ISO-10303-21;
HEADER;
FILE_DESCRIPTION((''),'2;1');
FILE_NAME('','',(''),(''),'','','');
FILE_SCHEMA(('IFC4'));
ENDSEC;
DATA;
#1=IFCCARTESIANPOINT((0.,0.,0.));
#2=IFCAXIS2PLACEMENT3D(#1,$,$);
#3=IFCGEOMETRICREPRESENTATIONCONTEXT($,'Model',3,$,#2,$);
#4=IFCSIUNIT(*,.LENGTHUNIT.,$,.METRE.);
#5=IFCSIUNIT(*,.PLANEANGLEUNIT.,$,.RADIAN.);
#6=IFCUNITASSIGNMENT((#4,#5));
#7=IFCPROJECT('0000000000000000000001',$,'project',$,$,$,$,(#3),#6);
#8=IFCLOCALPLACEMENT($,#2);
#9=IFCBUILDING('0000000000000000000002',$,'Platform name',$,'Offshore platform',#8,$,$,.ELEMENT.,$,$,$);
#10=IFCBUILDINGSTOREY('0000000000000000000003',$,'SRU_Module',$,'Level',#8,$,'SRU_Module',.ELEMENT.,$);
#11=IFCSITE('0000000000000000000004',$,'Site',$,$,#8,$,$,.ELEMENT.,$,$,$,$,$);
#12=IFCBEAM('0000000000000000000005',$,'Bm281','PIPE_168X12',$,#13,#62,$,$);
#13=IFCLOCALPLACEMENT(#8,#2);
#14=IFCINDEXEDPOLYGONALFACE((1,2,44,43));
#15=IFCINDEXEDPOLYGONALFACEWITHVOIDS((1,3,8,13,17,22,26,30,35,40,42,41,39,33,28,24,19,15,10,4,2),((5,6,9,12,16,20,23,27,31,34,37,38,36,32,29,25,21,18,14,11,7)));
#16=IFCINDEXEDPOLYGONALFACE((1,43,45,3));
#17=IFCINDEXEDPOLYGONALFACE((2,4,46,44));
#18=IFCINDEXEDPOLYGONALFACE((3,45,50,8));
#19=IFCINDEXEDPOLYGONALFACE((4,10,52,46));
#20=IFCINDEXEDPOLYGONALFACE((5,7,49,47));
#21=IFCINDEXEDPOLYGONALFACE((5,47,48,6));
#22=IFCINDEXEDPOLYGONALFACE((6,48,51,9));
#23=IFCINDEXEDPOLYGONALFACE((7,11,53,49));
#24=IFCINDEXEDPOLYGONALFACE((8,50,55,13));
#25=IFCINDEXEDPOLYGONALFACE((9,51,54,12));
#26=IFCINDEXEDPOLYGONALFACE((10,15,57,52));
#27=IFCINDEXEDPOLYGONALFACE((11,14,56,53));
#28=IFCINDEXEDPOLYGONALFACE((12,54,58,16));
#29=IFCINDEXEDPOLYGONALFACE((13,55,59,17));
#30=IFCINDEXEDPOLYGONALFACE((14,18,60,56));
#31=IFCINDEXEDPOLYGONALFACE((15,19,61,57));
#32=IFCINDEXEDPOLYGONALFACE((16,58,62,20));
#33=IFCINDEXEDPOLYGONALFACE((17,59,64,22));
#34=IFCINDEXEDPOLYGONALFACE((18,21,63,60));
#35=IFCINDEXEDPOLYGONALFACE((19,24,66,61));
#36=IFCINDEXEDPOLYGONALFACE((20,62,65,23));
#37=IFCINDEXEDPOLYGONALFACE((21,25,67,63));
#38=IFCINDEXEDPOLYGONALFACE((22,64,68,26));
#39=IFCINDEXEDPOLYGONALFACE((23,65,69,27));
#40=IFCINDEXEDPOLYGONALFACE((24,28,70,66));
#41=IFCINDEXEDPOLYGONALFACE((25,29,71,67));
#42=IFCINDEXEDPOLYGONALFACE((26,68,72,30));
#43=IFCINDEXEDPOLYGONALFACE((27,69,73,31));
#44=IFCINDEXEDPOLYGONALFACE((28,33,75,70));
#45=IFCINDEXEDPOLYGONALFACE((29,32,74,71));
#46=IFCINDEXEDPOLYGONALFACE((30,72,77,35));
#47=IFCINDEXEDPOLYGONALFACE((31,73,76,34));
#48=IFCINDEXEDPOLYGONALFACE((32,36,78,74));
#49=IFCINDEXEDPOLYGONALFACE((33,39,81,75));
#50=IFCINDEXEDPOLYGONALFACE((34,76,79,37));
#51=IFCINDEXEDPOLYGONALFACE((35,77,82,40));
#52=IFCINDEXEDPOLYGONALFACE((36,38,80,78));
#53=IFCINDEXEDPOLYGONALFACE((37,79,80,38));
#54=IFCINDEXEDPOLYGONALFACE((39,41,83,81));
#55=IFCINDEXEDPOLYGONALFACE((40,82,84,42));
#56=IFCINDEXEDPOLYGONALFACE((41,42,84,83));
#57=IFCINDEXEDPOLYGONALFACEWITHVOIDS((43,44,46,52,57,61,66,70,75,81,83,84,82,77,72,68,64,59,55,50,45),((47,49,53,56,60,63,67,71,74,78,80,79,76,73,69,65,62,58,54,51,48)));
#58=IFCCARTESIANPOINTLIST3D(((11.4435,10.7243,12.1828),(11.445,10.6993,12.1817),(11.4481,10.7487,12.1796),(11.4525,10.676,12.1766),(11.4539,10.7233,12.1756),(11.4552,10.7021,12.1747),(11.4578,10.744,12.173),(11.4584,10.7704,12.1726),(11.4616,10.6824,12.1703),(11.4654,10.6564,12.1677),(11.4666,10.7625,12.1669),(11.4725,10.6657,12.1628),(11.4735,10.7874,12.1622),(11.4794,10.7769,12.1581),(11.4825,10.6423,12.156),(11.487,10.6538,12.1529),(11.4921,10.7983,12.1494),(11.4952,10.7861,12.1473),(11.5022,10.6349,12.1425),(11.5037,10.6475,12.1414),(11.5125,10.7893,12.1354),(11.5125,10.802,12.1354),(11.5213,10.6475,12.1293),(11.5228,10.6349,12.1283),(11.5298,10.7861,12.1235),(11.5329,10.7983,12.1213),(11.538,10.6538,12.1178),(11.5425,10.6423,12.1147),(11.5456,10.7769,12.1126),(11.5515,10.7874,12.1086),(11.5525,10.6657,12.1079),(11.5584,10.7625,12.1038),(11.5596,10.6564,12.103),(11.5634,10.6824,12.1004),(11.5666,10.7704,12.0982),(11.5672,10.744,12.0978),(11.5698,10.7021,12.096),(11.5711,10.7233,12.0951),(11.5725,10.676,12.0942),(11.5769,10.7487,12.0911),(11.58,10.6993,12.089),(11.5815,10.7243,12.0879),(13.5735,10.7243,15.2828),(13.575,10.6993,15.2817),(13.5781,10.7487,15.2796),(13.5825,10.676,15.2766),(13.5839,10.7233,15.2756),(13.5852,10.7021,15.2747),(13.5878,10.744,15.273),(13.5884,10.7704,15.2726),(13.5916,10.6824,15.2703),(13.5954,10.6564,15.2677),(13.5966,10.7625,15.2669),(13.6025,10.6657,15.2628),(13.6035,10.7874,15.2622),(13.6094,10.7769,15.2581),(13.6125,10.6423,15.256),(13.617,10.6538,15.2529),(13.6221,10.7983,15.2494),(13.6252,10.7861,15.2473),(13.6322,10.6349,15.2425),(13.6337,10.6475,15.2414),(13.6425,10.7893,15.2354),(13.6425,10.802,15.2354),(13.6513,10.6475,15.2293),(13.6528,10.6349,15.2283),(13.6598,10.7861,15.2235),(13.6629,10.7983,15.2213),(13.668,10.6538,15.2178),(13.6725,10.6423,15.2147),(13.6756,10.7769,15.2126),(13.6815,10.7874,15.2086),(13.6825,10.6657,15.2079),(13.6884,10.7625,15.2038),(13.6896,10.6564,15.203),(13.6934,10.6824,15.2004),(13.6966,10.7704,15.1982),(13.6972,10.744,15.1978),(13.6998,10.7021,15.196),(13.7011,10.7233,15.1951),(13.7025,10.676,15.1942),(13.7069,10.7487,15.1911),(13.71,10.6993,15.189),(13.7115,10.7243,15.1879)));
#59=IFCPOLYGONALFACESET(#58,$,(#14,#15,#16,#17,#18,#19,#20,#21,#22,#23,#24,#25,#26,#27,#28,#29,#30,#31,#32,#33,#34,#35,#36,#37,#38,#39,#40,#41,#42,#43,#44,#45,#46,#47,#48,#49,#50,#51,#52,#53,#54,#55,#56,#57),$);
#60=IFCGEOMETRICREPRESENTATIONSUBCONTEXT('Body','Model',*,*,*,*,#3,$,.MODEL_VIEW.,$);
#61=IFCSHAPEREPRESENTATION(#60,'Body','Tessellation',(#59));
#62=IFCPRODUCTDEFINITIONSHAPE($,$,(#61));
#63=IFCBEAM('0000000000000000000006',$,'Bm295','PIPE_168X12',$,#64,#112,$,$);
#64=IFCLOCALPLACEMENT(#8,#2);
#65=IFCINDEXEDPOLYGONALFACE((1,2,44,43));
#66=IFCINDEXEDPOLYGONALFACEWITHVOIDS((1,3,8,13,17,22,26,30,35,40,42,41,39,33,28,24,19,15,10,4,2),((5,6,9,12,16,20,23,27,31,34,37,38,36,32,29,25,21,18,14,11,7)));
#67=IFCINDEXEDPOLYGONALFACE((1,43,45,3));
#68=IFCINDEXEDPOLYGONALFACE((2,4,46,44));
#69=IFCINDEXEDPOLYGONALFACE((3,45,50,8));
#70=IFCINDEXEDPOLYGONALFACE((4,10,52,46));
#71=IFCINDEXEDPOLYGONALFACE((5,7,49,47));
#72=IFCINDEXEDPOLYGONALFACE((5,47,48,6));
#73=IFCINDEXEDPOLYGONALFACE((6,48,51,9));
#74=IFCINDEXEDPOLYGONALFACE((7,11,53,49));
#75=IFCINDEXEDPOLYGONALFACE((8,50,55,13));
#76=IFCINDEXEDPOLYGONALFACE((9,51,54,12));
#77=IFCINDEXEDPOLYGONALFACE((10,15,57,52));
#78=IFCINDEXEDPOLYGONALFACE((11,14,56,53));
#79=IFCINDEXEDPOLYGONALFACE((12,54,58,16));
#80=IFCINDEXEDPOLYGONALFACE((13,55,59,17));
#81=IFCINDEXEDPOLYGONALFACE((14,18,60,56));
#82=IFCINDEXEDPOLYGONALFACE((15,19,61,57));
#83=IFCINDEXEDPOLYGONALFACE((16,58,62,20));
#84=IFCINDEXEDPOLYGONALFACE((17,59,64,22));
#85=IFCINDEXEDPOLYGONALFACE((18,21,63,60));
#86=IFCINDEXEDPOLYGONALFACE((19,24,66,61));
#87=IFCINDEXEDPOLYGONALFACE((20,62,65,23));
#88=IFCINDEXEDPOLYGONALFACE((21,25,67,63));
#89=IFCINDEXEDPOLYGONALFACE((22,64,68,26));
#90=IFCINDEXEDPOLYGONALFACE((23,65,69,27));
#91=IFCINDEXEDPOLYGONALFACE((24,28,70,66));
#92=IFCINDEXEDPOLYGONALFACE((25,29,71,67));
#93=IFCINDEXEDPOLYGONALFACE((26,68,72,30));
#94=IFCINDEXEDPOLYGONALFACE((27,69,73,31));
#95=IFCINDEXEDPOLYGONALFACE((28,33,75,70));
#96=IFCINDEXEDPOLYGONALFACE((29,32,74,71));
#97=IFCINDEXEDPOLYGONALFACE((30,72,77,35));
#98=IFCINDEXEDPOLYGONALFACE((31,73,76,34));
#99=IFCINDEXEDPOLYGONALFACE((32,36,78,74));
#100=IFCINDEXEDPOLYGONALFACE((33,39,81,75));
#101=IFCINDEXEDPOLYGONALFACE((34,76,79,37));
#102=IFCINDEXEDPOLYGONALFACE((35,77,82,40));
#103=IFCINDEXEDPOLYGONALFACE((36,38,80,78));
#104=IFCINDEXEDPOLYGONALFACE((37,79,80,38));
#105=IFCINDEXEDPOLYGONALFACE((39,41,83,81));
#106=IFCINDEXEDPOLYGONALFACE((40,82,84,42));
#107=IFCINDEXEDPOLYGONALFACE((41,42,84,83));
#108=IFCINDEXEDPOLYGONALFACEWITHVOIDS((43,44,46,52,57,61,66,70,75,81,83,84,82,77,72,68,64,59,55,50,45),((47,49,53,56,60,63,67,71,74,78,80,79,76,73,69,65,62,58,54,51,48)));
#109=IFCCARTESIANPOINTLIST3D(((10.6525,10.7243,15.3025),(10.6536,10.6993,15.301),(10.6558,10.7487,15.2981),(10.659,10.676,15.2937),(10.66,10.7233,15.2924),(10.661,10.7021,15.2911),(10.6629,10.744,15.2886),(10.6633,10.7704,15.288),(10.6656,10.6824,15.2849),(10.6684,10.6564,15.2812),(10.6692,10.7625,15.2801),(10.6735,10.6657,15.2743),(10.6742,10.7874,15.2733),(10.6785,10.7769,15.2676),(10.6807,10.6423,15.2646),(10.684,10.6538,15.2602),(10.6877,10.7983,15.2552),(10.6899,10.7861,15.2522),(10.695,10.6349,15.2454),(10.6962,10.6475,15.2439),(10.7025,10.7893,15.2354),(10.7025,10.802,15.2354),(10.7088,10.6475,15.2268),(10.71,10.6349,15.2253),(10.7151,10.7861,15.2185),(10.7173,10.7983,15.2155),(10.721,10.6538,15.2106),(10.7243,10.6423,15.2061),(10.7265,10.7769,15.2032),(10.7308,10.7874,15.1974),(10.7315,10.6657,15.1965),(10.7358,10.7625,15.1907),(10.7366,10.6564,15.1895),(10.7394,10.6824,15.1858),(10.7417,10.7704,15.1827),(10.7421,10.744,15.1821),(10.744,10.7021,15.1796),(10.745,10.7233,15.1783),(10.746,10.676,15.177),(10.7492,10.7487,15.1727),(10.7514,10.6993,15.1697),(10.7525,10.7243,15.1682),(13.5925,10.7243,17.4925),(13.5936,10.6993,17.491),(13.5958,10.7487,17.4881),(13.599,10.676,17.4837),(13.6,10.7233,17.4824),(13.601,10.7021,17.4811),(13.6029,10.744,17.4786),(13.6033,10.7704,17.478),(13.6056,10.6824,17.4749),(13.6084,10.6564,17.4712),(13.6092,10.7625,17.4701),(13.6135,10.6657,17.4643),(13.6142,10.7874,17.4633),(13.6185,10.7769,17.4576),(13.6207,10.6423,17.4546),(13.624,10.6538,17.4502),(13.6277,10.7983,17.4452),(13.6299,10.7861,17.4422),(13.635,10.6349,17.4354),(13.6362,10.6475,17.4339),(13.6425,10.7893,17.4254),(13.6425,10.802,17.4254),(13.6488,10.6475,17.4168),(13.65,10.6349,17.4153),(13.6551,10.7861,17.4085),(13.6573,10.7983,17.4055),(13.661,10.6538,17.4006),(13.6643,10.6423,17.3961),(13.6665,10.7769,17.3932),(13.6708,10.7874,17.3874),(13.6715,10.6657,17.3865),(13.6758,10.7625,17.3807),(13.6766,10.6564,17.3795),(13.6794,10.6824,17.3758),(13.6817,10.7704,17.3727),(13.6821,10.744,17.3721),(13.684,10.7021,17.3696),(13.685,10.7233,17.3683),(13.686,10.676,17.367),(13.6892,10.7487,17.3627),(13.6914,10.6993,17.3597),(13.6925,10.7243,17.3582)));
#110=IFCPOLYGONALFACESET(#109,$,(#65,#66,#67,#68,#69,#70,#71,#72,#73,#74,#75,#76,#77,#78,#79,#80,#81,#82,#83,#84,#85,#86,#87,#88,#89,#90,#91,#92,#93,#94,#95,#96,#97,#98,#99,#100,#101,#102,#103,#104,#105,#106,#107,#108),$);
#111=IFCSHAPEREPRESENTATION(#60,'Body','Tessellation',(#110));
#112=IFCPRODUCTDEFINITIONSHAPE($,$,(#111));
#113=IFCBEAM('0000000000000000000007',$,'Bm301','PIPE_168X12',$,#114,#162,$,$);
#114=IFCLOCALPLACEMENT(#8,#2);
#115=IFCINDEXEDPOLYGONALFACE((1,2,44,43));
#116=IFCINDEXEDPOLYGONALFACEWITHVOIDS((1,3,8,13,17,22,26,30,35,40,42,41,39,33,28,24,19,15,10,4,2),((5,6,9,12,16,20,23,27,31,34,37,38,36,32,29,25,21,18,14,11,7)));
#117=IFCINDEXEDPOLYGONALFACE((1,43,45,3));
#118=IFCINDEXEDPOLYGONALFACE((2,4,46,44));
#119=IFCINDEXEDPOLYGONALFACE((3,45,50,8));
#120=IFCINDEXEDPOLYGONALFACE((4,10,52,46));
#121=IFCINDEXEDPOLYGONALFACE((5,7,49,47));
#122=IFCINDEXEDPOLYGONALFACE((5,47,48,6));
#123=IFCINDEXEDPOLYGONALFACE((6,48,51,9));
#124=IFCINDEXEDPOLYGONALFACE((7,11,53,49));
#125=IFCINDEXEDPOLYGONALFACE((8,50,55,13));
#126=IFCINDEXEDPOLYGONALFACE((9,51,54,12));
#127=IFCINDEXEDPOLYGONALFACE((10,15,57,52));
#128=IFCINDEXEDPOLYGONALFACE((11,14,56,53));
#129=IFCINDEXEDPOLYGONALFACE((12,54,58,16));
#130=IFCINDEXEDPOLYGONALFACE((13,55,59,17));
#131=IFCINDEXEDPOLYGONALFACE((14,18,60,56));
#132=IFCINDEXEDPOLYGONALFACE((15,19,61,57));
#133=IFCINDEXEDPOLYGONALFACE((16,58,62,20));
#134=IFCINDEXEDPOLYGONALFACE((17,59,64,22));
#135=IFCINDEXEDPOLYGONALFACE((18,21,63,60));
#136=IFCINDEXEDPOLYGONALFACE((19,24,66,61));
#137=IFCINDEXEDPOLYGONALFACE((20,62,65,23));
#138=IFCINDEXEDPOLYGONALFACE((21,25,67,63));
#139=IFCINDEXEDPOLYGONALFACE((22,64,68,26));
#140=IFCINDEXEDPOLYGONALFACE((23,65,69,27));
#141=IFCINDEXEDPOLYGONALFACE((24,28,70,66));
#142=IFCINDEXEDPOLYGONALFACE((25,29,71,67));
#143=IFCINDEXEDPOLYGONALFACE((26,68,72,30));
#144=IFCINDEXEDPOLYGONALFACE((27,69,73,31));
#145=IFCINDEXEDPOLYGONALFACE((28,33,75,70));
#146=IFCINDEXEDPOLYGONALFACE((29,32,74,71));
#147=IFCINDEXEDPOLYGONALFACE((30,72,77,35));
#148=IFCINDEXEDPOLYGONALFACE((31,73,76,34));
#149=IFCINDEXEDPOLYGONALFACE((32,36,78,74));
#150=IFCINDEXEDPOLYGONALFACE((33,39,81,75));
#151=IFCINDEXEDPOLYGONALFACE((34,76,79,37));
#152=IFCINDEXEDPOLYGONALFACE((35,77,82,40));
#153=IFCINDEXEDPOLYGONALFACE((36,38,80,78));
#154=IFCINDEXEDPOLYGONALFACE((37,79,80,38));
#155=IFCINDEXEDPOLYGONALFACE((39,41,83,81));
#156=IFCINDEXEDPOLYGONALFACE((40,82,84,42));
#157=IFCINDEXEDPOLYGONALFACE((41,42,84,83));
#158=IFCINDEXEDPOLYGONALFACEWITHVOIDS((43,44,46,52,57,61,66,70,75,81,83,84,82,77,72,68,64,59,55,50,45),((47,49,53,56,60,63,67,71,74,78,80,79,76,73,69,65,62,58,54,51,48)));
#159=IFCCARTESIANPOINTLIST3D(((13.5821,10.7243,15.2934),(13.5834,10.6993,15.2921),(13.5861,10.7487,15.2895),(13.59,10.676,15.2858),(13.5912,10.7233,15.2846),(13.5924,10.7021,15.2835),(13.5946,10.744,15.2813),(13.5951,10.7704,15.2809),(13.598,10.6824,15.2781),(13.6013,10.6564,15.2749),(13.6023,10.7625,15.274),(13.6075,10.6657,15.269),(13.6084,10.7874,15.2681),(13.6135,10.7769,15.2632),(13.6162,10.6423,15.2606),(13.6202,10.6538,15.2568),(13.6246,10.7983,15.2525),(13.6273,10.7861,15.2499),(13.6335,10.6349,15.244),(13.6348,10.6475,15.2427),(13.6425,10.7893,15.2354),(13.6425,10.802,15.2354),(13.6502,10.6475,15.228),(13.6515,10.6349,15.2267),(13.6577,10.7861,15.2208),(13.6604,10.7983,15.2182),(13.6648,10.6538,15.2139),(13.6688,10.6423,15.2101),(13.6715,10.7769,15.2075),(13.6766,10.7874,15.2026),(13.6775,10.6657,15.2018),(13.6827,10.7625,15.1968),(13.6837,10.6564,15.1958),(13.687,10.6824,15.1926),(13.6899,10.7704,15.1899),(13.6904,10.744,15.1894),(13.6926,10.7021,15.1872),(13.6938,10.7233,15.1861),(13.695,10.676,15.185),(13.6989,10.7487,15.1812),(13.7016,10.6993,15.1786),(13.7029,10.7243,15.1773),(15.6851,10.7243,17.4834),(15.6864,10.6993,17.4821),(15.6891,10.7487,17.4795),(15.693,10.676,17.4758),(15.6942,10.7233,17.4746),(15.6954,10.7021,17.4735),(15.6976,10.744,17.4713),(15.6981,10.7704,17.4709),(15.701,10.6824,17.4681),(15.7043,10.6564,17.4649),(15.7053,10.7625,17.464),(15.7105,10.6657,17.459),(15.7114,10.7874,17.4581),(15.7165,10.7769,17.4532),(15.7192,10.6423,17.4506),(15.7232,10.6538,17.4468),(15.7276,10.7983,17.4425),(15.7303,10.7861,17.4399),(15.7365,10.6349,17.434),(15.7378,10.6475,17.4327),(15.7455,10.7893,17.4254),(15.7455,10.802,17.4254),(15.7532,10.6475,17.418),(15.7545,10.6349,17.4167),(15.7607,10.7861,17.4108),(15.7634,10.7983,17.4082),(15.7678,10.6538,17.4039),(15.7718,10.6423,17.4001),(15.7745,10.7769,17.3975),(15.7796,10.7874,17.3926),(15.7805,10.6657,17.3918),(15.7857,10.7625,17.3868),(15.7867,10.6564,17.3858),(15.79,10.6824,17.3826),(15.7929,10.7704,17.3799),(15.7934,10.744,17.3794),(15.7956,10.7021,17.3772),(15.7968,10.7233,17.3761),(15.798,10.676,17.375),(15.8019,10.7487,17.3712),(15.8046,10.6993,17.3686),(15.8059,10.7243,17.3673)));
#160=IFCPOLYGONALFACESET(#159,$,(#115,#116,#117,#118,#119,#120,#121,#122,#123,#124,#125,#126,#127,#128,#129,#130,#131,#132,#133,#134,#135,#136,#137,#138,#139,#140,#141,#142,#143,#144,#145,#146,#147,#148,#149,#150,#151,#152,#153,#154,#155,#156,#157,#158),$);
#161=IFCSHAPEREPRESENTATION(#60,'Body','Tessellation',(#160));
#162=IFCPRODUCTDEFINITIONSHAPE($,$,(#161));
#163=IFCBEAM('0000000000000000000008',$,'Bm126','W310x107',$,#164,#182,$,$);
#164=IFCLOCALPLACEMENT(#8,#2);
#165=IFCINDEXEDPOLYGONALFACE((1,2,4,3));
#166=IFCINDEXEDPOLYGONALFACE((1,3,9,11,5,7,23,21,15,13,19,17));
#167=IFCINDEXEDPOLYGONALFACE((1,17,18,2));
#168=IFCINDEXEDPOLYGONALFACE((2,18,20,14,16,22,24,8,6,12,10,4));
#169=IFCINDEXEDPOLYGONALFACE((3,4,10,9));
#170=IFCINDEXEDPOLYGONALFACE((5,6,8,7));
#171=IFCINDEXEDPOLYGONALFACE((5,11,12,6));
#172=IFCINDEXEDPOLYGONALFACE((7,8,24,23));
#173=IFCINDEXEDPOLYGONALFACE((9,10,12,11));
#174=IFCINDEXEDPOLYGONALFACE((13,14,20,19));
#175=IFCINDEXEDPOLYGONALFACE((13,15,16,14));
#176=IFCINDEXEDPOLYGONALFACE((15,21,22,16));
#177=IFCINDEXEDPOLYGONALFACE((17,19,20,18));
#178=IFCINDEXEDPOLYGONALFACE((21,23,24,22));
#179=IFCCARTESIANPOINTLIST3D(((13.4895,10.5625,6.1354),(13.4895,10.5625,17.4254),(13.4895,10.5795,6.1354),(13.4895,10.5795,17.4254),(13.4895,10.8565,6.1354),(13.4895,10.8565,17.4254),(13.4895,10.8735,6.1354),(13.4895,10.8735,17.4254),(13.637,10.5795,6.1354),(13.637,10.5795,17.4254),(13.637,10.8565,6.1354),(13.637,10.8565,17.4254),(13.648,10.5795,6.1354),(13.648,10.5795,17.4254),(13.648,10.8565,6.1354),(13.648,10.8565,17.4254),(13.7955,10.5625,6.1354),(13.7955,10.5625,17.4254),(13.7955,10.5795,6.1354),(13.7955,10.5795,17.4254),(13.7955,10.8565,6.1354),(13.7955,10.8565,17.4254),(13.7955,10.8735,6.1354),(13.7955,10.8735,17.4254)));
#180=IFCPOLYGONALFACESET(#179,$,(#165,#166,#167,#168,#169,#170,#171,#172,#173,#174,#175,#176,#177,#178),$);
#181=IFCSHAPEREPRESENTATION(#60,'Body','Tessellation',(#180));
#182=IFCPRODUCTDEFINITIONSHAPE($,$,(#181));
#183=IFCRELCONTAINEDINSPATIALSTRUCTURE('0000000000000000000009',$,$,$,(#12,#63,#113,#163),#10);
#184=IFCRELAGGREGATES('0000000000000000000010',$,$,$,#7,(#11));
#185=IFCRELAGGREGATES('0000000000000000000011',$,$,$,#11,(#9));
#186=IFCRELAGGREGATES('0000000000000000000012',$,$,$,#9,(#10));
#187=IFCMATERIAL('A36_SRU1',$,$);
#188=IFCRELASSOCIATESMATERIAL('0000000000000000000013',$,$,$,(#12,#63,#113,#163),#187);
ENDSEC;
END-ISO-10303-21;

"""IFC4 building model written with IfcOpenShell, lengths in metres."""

from ifc_helpers import new_model, si_unit, frame, origin, origin_with_axes, origin_2d, place, context, subcontext, project, spatial, hollow_circle, i_section, extrude, source, transform, mapped, material, element, save


model = new_model("IFC4")

# Units and contexts
model_context = context("Model", 3, world=origin())
body_context = subcontext(model_context, "Body", "Model", "MODEL_VIEW")
ifc_project = project(units=[si_unit("LENGTHUNIT", "METRE"), si_unit("PLANEANGLEUNIT", "RADIAN")], contexts=[model_context])

# Site, building, storey
placement_1 = place(None, origin())
site = spatial("IfcSite", under=ifc_project, at=placement_1, Name="Site", CompositionType="ELEMENT")
building = spatial("IfcBuilding", under=site, at=placement_1, Name="Platform name", ObjectType="Offshore platform", CompositionType="ELEMENT")
storey = spatial("IfcBuildingStorey", under=building, at=placement_1, Name="SRU_Module", ObjectType="Level", LongName="SRU_Module", CompositionType="ELEMENT")

# Beams
ifc_material = material(Name="A36_SRU1")
shared_shape_1 = source(origin(), body_context, "Body", "SweptSolid", [
    extrude(hollow_circle(Radius=0.084, WallThickness=0.0127, at=origin_2d()), frame((0.0, 0.0, 0.0), z_axis=(0.566303, 0.0, 0.824197), x_axis=(0.0, 1.0, 0.0)), (0.0, 0.0, 1.0), 3.7612),
])
placement_2 = place(None, origin())
placement_3 = place(placement_2, origin())
placement_4 = place(placement_3, origin())
beam_1_placement = place(placement_4, frame((11.5125, 10.718, 12.1354)))
element("IfcBeam", 1, at=beam_1_placement, inside=storey, material=ifc_material, Name="Bm281", Description="PIPE_168X12", context=body_context, shape_type="MappedRepresentation", body=[
    mapped(shared_shape_1, transform((0.0, 0.0, 0.0), scale=1.0)),
])
shared_shape_2 = source(origin(), body_context, "Body", "SweptSolid", [
    extrude(hollow_circle(Radius=0.084, WallThickness=0.0127, at=origin_2d()), frame((0.0, 0.0, 0.0), z_axis=(0.80196, 0.0, 0.597378), x_axis=(0.0, 1.0, 0.0)), (0.0, 0.0, 1.0), 3.666),
])
placement_5 = place(None, origin())
placement_6 = place(placement_5, origin())
placement_7 = place(placement_6, origin())
beam_2_placement = place(placement_7, frame((10.7025, 10.718, 15.2354)))
element("IfcBeam", 2, at=beam_2_placement, inside=storey, material=ifc_material, Name="Bm295", Description="PIPE_168X12", context=body_context, shape_type="MappedRepresentation", body=[
    mapped(shared_shape_2, transform((0.0, 0.0, 0.0), scale=1.0)),
])
shared_shape_3 = source(origin(), body_context, "Body", "SweptSolid", [
    extrude(hollow_circle(Radius=0.084, WallThickness=0.0127, at=origin_2d()), frame((0.0, 0.0, 0.0), z_axis=(0.692635, 0.0, 0.721289), x_axis=(0.0, 1.0, 0.0)), (0.0, 0.0, 1.0), 3.0362),
])
placement_8 = place(None, origin())
placement_9 = place(placement_8, origin())
placement_10 = place(placement_9, origin())
beam_3_placement = place(placement_10, frame((13.6425, 10.718, 15.2354)))
element("IfcBeam", 3, at=beam_3_placement, inside=storey, material=ifc_material, Name="Bm301", Description="PIPE_168X12", context=body_context, shape_type="MappedRepresentation", body=[
    mapped(shared_shape_3, transform((0.0, 0.0, 0.0), scale=1.0)),
])
shared_shape_4 = source(origin(), body_context, "Body", "SweptSolid", [
    extrude(i_section(OverallWidth=0.306, OverallDepth=0.311, WebThickness=0.0109, FlangeThickness=0.017, FilletRadius=0.0, at=origin_2d()), origin_with_axes(), (0.0, 0.0, 1.0), 11.29),
])
placement_11 = place(None, origin())
placement_12 = place(placement_11, origin())
placement_13 = place(placement_12, origin())
beam_4_placement = place(placement_13, frame((13.6425, 10.718, 6.1354)))
element("IfcBeam", 4, at=beam_4_placement, inside=storey, material=ifc_material, Name="Bm126", Description="W310x107", context=body_context, shape_type="MappedRepresentation", body=[
    mapped(shared_shape_4, transform((0.0, 0.0, 0.0), scale=1.0)),
])

save(model, "model.ifc")
